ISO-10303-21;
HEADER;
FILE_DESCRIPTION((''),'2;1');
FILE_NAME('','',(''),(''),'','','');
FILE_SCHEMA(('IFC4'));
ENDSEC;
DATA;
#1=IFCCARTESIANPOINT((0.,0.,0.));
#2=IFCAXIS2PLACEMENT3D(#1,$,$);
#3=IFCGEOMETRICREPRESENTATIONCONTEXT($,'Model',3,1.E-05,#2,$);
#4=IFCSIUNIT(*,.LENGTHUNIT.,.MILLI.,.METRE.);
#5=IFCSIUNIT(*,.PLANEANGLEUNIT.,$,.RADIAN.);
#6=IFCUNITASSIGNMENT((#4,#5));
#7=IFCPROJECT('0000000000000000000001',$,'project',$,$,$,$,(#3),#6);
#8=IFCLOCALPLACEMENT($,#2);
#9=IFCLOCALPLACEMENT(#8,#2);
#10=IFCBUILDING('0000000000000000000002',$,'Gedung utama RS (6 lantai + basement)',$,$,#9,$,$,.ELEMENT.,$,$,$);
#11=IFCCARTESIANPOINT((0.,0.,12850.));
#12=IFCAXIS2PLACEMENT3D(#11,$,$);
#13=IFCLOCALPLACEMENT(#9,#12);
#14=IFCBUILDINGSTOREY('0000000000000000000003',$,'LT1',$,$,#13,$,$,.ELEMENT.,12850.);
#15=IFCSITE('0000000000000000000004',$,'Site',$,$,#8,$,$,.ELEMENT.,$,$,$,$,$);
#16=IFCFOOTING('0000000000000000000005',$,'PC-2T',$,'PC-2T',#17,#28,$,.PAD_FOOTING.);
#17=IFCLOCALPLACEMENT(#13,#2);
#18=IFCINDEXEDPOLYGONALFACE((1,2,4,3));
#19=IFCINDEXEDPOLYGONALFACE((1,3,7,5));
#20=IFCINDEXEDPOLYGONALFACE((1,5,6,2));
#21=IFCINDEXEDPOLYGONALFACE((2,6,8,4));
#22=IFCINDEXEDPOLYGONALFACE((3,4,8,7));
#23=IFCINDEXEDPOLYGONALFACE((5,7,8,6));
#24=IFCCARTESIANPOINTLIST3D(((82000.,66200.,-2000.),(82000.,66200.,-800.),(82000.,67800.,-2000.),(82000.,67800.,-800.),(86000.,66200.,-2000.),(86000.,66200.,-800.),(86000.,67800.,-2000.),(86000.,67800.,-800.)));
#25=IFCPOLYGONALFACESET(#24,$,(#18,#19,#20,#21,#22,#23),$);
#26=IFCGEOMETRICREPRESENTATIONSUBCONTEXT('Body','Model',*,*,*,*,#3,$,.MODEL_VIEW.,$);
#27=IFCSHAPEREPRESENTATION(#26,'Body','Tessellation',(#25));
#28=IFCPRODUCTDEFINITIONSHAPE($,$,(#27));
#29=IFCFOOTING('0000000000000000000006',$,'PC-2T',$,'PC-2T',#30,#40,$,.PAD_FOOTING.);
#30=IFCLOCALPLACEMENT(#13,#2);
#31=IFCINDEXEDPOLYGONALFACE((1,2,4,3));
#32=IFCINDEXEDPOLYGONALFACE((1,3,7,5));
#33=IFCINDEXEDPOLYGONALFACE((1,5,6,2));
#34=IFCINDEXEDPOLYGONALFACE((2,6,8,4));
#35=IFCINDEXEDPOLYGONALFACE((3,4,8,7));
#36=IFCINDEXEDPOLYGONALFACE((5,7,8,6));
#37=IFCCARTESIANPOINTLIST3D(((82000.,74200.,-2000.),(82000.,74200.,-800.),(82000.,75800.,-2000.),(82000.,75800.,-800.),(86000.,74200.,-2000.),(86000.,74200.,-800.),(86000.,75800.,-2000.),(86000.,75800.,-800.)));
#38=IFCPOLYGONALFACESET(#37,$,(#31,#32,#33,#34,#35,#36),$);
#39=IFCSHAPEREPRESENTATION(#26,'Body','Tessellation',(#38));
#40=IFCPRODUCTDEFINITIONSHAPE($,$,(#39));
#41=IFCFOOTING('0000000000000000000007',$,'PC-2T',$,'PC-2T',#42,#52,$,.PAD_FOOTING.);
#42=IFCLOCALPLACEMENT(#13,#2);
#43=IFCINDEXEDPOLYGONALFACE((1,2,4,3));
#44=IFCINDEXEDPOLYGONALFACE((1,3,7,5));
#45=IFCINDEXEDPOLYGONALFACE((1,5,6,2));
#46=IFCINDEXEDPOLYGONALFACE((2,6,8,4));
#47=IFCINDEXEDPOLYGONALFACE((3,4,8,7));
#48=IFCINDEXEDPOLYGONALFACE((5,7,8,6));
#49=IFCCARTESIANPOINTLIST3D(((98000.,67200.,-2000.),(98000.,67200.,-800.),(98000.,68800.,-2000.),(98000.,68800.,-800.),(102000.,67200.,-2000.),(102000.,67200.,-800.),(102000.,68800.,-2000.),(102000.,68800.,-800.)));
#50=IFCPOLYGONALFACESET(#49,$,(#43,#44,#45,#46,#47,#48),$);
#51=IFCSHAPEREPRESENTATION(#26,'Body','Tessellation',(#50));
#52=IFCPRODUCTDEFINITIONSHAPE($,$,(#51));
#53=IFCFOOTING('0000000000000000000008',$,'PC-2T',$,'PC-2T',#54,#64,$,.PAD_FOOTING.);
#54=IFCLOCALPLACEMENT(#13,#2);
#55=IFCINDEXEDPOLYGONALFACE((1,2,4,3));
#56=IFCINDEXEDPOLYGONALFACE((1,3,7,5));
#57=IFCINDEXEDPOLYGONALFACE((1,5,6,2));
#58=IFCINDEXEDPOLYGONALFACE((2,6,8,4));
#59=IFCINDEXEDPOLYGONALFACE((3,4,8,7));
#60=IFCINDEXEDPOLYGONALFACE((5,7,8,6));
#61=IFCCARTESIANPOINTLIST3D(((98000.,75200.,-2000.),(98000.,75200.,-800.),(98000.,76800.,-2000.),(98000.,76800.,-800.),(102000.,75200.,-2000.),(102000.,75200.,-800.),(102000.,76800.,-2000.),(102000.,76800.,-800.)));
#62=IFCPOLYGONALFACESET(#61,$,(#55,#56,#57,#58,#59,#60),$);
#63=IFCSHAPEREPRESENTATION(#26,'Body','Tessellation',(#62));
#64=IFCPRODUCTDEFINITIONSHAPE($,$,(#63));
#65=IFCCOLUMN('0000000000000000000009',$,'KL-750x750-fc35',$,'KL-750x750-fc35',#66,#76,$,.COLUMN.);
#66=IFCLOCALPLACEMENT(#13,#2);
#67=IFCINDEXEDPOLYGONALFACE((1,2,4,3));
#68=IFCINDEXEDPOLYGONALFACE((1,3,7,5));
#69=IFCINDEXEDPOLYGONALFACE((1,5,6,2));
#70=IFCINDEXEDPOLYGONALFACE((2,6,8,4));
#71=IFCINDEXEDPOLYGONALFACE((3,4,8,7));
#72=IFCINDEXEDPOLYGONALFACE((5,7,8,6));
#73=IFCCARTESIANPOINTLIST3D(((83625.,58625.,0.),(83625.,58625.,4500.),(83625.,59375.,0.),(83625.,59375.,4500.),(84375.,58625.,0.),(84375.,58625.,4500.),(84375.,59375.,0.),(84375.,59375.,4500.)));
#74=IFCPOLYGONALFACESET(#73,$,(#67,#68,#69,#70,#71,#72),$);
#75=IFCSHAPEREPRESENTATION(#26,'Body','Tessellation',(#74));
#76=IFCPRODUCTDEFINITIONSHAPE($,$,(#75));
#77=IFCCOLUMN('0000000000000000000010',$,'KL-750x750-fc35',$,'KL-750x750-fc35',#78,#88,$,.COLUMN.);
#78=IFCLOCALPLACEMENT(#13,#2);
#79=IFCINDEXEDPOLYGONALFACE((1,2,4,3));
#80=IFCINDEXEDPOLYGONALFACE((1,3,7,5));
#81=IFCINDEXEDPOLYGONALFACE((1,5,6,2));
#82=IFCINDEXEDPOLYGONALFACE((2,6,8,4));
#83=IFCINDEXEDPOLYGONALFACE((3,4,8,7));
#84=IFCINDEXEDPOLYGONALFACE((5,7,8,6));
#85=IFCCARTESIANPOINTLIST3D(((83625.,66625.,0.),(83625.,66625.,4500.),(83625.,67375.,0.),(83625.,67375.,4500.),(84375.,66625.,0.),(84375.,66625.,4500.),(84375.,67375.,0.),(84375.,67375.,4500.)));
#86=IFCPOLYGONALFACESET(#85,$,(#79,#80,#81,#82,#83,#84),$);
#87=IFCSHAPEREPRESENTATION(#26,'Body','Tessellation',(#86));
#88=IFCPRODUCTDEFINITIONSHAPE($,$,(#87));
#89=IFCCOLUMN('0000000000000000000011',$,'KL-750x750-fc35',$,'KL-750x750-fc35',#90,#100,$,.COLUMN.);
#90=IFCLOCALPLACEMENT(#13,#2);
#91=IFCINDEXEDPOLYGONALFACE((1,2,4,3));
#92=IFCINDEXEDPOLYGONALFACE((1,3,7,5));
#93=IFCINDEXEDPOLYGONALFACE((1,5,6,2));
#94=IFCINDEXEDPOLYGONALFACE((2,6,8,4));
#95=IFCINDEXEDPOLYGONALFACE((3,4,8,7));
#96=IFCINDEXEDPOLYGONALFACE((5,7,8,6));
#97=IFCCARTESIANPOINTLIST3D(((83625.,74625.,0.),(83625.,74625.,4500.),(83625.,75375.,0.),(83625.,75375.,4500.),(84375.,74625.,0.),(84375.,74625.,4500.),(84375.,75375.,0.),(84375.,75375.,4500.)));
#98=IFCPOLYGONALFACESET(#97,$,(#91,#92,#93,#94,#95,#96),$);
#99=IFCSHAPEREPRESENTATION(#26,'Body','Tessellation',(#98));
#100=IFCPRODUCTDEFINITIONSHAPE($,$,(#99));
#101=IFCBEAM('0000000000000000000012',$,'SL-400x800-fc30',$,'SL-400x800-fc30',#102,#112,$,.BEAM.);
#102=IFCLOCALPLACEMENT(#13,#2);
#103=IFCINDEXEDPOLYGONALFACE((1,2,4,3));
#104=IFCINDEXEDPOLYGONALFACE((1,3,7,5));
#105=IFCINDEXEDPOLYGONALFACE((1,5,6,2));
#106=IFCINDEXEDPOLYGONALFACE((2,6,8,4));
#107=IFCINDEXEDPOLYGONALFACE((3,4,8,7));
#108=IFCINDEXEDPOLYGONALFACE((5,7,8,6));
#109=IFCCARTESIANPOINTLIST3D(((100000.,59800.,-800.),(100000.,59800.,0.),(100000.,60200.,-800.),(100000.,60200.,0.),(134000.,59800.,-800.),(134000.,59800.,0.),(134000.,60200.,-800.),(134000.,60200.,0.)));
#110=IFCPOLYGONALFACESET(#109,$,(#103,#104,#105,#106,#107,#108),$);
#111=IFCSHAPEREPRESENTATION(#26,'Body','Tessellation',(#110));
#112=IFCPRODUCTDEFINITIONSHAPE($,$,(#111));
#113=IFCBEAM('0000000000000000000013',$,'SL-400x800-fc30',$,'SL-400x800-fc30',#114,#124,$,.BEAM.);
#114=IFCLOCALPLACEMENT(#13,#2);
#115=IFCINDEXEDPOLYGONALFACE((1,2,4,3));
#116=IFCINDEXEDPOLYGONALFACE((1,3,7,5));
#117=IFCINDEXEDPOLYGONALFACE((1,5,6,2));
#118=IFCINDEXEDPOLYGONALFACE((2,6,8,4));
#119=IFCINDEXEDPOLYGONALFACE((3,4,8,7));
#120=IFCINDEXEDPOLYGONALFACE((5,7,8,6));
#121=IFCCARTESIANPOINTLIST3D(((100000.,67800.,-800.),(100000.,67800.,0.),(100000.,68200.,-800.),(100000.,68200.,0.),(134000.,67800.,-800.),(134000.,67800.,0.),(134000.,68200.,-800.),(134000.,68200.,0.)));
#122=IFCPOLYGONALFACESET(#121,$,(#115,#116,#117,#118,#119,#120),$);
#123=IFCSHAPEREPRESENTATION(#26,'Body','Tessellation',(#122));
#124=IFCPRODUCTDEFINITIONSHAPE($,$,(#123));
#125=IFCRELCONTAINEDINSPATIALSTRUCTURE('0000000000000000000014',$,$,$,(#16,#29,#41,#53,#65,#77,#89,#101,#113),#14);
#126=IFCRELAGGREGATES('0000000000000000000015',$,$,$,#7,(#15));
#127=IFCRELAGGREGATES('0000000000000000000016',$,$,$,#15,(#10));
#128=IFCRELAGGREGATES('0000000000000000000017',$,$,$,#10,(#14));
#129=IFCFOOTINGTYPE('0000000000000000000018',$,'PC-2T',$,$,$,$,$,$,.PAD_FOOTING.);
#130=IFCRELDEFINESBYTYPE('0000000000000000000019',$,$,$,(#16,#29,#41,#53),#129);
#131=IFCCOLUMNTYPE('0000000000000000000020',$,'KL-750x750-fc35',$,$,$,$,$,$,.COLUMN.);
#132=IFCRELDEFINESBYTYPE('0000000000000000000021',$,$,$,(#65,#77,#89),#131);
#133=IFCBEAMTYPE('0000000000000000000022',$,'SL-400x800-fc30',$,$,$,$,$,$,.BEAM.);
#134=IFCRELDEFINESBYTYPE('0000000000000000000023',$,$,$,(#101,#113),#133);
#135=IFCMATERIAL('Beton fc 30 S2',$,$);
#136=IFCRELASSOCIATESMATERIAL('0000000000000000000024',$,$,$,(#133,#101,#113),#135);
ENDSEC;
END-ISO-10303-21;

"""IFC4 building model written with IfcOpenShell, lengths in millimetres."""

from ifc_helpers import new_model, si_unit, frame, origin, origin_2d, place, context, subcontext, project, spatial, rectangle, extrude, material, material_profile, profile_set, profile_usage, type_object, element, save


model = new_model("IFC4")

# Units and contexts
model_context = context("Model", 3, precision=1e-05, world=origin())
body_context = subcontext(model_context, "Body", "Model", "MODEL_VIEW")
ifc_project = project(units=[si_unit("LENGTHUNIT", "METRE", prefix="MILLI"), si_unit("PLANEANGLEUNIT", "RADIAN")], contexts=[model_context])

# Site, building, storey
site_placement = place(None, origin())
site = spatial("IfcSite", under=ifc_project, at=site_placement, Name="Site", CompositionType="ELEMENT")
building_placement = place(site_placement, origin())
building = spatial("IfcBuilding", under=site, at=building_placement, Name="Gedung utama RS (6 lantai + basement)", CompositionType="ELEMENT")
storey_placement = place(building_placement, frame((0.0, 0.0, 12850.0)))
storey = spatial("IfcBuildingStorey", under=building, at=storey_placement, Name="LT1", CompositionType="ELEMENT", Elevation=12850.0)

# Footings
ifc_material_profile_1 = material_profile(None, rectangle(XDim=4000.0, YDim=1600.0, at=origin_2d()), Name="PC-2T")
ifc_profile_set_1 = profile_set([ifc_material_profile_1], Name="PC-2T")
ifc_profile_usage_1 = profile_usage(ifc_profile_set_1, cardinal=5)
footing_type = type_object("IfcFootingType", Name="PC-2T", PredefinedType="PAD_FOOTING", material=ifc_profile_set_1)
for number, where, z_axis, x_axis, name in (
    (1, (84000.0, 67000.0, -2000.0), (0.0, 0.0, 1.0), (1.0, 0.0, 0.0), "PC-2T"),
    (2, (84000.0, 75000.0, -2000.0), (0.0, 0.0, 1.0), (1.0, 0.0, 0.0), "PC-2T"),
    (3, (100000.0, 68000.0, -2000.0), (0.0, 0.0, 1.0), (1.0, 0.0, 0.0), "PC-2T"),
    (4, (100000.0, 76000.0, -2000.0), (0.0, 0.0, 1.0), (1.0, 0.0, 0.0), "PC-2T"),
):
    element("IfcFooting", number, at=place(storey_placement, frame(where, z_axis=z_axis, x_axis=x_axis)), inside=storey, type_object=footing_type, material=ifc_profile_usage_1, Name=name, ObjectType="PC-2T", PredefinedType="PAD_FOOTING", context=body_context, shape_type="SweptSolid", body=[
        extrude(rectangle(XDim=4000.0, YDim=1600.0, at=origin_2d()), origin(), (0.0, 0.0, 1.0), 1200.0),
    ])

# Columns
ifc_material_profile_2 = material_profile(None, rectangle(XDim=750.0, YDim=750.0, at=origin_2d()), Name="KL-750x750-fc35")
ifc_profile_set_2 = profile_set([ifc_material_profile_2], Name="KL-750x750-fc35")
ifc_profile_usage_2 = profile_usage(ifc_profile_set_2, cardinal=5)
column_type = type_object("IfcColumnType", Name="KL-750x750-fc35", PredefinedType="COLUMN", material=ifc_profile_set_2)
for number, where, z_axis, x_axis, name in (
    (5, (84000.0, 59000.0, 0.0), (0.0, 0.0, 1.0), (1.0, 0.0, 0.0), "KL-750x750-fc35"),
    (6, (84000.0, 67000.0, 0.0), (0.0, 0.0, 1.0), (1.0, 0.0, 0.0), "KL-750x750-fc35"),
    (7, (84000.0, 75000.0, 0.0), (0.0, 0.0, 1.0), (1.0, 0.0, 0.0), "KL-750x750-fc35"),
):
    element("IfcColumn", number, at=place(storey_placement, frame(where, z_axis=z_axis, x_axis=x_axis)), inside=storey, type_object=column_type, material=ifc_profile_usage_2, Name=name, ObjectType="KL-750x750-fc35", PredefinedType="COLUMN", context=body_context, shape_type="SweptSolid", body=[
        extrude(rectangle(XDim=750.0, YDim=750.0, at=origin_2d()), origin(), (0.0, 0.0, 1.0), 4500.0),
    ])

# Beams
ifc_material_1 = material(Name="Beton fc 30 S2")
ifc_material_profile_3 = material_profile(ifc_material_1, rectangle(XDim=400.0, YDim=800.0, at=origin_2d()), Name="SL-400x800-fc30")
ifc_profile_set_3 = profile_set([ifc_material_profile_3], Name="SL-400x800-fc30")
ifc_profile_usage_3 = profile_usage(ifc_profile_set_3, cardinal=8)
beam_type = type_object("IfcBeamType", Name="SL-400x800-fc30", PredefinedType="BEAM", material=ifc_profile_set_3)
for number, where, name in (
    (8, (100000.0, 60000.0, -400.0), "SL-400x800-fc30"),
    (9, (100000.0, 68000.0, -400.0), "SL-400x800-fc30"),
):
    element("IfcBeam", number, at=place(storey_placement, frame(where)), inside=storey, type_object=beam_type, material=ifc_profile_usage_3, Name=name, ObjectType="SL-400x800-fc30", PredefinedType="BEAM", context=body_context, shape_type="SweptSolid", body=[
        extrude(rectangle(XDim=400.0, YDim=800.0, at=origin_2d()), frame((0.0, 0.0, 0.0), z_axis=(1.0, 0.0, 0.0), x_axis=(0.0, 1.0, 0.0)), (0.0, 0.0, 1.0), 34000.0),
    ])

save(model, "model.ifc")
